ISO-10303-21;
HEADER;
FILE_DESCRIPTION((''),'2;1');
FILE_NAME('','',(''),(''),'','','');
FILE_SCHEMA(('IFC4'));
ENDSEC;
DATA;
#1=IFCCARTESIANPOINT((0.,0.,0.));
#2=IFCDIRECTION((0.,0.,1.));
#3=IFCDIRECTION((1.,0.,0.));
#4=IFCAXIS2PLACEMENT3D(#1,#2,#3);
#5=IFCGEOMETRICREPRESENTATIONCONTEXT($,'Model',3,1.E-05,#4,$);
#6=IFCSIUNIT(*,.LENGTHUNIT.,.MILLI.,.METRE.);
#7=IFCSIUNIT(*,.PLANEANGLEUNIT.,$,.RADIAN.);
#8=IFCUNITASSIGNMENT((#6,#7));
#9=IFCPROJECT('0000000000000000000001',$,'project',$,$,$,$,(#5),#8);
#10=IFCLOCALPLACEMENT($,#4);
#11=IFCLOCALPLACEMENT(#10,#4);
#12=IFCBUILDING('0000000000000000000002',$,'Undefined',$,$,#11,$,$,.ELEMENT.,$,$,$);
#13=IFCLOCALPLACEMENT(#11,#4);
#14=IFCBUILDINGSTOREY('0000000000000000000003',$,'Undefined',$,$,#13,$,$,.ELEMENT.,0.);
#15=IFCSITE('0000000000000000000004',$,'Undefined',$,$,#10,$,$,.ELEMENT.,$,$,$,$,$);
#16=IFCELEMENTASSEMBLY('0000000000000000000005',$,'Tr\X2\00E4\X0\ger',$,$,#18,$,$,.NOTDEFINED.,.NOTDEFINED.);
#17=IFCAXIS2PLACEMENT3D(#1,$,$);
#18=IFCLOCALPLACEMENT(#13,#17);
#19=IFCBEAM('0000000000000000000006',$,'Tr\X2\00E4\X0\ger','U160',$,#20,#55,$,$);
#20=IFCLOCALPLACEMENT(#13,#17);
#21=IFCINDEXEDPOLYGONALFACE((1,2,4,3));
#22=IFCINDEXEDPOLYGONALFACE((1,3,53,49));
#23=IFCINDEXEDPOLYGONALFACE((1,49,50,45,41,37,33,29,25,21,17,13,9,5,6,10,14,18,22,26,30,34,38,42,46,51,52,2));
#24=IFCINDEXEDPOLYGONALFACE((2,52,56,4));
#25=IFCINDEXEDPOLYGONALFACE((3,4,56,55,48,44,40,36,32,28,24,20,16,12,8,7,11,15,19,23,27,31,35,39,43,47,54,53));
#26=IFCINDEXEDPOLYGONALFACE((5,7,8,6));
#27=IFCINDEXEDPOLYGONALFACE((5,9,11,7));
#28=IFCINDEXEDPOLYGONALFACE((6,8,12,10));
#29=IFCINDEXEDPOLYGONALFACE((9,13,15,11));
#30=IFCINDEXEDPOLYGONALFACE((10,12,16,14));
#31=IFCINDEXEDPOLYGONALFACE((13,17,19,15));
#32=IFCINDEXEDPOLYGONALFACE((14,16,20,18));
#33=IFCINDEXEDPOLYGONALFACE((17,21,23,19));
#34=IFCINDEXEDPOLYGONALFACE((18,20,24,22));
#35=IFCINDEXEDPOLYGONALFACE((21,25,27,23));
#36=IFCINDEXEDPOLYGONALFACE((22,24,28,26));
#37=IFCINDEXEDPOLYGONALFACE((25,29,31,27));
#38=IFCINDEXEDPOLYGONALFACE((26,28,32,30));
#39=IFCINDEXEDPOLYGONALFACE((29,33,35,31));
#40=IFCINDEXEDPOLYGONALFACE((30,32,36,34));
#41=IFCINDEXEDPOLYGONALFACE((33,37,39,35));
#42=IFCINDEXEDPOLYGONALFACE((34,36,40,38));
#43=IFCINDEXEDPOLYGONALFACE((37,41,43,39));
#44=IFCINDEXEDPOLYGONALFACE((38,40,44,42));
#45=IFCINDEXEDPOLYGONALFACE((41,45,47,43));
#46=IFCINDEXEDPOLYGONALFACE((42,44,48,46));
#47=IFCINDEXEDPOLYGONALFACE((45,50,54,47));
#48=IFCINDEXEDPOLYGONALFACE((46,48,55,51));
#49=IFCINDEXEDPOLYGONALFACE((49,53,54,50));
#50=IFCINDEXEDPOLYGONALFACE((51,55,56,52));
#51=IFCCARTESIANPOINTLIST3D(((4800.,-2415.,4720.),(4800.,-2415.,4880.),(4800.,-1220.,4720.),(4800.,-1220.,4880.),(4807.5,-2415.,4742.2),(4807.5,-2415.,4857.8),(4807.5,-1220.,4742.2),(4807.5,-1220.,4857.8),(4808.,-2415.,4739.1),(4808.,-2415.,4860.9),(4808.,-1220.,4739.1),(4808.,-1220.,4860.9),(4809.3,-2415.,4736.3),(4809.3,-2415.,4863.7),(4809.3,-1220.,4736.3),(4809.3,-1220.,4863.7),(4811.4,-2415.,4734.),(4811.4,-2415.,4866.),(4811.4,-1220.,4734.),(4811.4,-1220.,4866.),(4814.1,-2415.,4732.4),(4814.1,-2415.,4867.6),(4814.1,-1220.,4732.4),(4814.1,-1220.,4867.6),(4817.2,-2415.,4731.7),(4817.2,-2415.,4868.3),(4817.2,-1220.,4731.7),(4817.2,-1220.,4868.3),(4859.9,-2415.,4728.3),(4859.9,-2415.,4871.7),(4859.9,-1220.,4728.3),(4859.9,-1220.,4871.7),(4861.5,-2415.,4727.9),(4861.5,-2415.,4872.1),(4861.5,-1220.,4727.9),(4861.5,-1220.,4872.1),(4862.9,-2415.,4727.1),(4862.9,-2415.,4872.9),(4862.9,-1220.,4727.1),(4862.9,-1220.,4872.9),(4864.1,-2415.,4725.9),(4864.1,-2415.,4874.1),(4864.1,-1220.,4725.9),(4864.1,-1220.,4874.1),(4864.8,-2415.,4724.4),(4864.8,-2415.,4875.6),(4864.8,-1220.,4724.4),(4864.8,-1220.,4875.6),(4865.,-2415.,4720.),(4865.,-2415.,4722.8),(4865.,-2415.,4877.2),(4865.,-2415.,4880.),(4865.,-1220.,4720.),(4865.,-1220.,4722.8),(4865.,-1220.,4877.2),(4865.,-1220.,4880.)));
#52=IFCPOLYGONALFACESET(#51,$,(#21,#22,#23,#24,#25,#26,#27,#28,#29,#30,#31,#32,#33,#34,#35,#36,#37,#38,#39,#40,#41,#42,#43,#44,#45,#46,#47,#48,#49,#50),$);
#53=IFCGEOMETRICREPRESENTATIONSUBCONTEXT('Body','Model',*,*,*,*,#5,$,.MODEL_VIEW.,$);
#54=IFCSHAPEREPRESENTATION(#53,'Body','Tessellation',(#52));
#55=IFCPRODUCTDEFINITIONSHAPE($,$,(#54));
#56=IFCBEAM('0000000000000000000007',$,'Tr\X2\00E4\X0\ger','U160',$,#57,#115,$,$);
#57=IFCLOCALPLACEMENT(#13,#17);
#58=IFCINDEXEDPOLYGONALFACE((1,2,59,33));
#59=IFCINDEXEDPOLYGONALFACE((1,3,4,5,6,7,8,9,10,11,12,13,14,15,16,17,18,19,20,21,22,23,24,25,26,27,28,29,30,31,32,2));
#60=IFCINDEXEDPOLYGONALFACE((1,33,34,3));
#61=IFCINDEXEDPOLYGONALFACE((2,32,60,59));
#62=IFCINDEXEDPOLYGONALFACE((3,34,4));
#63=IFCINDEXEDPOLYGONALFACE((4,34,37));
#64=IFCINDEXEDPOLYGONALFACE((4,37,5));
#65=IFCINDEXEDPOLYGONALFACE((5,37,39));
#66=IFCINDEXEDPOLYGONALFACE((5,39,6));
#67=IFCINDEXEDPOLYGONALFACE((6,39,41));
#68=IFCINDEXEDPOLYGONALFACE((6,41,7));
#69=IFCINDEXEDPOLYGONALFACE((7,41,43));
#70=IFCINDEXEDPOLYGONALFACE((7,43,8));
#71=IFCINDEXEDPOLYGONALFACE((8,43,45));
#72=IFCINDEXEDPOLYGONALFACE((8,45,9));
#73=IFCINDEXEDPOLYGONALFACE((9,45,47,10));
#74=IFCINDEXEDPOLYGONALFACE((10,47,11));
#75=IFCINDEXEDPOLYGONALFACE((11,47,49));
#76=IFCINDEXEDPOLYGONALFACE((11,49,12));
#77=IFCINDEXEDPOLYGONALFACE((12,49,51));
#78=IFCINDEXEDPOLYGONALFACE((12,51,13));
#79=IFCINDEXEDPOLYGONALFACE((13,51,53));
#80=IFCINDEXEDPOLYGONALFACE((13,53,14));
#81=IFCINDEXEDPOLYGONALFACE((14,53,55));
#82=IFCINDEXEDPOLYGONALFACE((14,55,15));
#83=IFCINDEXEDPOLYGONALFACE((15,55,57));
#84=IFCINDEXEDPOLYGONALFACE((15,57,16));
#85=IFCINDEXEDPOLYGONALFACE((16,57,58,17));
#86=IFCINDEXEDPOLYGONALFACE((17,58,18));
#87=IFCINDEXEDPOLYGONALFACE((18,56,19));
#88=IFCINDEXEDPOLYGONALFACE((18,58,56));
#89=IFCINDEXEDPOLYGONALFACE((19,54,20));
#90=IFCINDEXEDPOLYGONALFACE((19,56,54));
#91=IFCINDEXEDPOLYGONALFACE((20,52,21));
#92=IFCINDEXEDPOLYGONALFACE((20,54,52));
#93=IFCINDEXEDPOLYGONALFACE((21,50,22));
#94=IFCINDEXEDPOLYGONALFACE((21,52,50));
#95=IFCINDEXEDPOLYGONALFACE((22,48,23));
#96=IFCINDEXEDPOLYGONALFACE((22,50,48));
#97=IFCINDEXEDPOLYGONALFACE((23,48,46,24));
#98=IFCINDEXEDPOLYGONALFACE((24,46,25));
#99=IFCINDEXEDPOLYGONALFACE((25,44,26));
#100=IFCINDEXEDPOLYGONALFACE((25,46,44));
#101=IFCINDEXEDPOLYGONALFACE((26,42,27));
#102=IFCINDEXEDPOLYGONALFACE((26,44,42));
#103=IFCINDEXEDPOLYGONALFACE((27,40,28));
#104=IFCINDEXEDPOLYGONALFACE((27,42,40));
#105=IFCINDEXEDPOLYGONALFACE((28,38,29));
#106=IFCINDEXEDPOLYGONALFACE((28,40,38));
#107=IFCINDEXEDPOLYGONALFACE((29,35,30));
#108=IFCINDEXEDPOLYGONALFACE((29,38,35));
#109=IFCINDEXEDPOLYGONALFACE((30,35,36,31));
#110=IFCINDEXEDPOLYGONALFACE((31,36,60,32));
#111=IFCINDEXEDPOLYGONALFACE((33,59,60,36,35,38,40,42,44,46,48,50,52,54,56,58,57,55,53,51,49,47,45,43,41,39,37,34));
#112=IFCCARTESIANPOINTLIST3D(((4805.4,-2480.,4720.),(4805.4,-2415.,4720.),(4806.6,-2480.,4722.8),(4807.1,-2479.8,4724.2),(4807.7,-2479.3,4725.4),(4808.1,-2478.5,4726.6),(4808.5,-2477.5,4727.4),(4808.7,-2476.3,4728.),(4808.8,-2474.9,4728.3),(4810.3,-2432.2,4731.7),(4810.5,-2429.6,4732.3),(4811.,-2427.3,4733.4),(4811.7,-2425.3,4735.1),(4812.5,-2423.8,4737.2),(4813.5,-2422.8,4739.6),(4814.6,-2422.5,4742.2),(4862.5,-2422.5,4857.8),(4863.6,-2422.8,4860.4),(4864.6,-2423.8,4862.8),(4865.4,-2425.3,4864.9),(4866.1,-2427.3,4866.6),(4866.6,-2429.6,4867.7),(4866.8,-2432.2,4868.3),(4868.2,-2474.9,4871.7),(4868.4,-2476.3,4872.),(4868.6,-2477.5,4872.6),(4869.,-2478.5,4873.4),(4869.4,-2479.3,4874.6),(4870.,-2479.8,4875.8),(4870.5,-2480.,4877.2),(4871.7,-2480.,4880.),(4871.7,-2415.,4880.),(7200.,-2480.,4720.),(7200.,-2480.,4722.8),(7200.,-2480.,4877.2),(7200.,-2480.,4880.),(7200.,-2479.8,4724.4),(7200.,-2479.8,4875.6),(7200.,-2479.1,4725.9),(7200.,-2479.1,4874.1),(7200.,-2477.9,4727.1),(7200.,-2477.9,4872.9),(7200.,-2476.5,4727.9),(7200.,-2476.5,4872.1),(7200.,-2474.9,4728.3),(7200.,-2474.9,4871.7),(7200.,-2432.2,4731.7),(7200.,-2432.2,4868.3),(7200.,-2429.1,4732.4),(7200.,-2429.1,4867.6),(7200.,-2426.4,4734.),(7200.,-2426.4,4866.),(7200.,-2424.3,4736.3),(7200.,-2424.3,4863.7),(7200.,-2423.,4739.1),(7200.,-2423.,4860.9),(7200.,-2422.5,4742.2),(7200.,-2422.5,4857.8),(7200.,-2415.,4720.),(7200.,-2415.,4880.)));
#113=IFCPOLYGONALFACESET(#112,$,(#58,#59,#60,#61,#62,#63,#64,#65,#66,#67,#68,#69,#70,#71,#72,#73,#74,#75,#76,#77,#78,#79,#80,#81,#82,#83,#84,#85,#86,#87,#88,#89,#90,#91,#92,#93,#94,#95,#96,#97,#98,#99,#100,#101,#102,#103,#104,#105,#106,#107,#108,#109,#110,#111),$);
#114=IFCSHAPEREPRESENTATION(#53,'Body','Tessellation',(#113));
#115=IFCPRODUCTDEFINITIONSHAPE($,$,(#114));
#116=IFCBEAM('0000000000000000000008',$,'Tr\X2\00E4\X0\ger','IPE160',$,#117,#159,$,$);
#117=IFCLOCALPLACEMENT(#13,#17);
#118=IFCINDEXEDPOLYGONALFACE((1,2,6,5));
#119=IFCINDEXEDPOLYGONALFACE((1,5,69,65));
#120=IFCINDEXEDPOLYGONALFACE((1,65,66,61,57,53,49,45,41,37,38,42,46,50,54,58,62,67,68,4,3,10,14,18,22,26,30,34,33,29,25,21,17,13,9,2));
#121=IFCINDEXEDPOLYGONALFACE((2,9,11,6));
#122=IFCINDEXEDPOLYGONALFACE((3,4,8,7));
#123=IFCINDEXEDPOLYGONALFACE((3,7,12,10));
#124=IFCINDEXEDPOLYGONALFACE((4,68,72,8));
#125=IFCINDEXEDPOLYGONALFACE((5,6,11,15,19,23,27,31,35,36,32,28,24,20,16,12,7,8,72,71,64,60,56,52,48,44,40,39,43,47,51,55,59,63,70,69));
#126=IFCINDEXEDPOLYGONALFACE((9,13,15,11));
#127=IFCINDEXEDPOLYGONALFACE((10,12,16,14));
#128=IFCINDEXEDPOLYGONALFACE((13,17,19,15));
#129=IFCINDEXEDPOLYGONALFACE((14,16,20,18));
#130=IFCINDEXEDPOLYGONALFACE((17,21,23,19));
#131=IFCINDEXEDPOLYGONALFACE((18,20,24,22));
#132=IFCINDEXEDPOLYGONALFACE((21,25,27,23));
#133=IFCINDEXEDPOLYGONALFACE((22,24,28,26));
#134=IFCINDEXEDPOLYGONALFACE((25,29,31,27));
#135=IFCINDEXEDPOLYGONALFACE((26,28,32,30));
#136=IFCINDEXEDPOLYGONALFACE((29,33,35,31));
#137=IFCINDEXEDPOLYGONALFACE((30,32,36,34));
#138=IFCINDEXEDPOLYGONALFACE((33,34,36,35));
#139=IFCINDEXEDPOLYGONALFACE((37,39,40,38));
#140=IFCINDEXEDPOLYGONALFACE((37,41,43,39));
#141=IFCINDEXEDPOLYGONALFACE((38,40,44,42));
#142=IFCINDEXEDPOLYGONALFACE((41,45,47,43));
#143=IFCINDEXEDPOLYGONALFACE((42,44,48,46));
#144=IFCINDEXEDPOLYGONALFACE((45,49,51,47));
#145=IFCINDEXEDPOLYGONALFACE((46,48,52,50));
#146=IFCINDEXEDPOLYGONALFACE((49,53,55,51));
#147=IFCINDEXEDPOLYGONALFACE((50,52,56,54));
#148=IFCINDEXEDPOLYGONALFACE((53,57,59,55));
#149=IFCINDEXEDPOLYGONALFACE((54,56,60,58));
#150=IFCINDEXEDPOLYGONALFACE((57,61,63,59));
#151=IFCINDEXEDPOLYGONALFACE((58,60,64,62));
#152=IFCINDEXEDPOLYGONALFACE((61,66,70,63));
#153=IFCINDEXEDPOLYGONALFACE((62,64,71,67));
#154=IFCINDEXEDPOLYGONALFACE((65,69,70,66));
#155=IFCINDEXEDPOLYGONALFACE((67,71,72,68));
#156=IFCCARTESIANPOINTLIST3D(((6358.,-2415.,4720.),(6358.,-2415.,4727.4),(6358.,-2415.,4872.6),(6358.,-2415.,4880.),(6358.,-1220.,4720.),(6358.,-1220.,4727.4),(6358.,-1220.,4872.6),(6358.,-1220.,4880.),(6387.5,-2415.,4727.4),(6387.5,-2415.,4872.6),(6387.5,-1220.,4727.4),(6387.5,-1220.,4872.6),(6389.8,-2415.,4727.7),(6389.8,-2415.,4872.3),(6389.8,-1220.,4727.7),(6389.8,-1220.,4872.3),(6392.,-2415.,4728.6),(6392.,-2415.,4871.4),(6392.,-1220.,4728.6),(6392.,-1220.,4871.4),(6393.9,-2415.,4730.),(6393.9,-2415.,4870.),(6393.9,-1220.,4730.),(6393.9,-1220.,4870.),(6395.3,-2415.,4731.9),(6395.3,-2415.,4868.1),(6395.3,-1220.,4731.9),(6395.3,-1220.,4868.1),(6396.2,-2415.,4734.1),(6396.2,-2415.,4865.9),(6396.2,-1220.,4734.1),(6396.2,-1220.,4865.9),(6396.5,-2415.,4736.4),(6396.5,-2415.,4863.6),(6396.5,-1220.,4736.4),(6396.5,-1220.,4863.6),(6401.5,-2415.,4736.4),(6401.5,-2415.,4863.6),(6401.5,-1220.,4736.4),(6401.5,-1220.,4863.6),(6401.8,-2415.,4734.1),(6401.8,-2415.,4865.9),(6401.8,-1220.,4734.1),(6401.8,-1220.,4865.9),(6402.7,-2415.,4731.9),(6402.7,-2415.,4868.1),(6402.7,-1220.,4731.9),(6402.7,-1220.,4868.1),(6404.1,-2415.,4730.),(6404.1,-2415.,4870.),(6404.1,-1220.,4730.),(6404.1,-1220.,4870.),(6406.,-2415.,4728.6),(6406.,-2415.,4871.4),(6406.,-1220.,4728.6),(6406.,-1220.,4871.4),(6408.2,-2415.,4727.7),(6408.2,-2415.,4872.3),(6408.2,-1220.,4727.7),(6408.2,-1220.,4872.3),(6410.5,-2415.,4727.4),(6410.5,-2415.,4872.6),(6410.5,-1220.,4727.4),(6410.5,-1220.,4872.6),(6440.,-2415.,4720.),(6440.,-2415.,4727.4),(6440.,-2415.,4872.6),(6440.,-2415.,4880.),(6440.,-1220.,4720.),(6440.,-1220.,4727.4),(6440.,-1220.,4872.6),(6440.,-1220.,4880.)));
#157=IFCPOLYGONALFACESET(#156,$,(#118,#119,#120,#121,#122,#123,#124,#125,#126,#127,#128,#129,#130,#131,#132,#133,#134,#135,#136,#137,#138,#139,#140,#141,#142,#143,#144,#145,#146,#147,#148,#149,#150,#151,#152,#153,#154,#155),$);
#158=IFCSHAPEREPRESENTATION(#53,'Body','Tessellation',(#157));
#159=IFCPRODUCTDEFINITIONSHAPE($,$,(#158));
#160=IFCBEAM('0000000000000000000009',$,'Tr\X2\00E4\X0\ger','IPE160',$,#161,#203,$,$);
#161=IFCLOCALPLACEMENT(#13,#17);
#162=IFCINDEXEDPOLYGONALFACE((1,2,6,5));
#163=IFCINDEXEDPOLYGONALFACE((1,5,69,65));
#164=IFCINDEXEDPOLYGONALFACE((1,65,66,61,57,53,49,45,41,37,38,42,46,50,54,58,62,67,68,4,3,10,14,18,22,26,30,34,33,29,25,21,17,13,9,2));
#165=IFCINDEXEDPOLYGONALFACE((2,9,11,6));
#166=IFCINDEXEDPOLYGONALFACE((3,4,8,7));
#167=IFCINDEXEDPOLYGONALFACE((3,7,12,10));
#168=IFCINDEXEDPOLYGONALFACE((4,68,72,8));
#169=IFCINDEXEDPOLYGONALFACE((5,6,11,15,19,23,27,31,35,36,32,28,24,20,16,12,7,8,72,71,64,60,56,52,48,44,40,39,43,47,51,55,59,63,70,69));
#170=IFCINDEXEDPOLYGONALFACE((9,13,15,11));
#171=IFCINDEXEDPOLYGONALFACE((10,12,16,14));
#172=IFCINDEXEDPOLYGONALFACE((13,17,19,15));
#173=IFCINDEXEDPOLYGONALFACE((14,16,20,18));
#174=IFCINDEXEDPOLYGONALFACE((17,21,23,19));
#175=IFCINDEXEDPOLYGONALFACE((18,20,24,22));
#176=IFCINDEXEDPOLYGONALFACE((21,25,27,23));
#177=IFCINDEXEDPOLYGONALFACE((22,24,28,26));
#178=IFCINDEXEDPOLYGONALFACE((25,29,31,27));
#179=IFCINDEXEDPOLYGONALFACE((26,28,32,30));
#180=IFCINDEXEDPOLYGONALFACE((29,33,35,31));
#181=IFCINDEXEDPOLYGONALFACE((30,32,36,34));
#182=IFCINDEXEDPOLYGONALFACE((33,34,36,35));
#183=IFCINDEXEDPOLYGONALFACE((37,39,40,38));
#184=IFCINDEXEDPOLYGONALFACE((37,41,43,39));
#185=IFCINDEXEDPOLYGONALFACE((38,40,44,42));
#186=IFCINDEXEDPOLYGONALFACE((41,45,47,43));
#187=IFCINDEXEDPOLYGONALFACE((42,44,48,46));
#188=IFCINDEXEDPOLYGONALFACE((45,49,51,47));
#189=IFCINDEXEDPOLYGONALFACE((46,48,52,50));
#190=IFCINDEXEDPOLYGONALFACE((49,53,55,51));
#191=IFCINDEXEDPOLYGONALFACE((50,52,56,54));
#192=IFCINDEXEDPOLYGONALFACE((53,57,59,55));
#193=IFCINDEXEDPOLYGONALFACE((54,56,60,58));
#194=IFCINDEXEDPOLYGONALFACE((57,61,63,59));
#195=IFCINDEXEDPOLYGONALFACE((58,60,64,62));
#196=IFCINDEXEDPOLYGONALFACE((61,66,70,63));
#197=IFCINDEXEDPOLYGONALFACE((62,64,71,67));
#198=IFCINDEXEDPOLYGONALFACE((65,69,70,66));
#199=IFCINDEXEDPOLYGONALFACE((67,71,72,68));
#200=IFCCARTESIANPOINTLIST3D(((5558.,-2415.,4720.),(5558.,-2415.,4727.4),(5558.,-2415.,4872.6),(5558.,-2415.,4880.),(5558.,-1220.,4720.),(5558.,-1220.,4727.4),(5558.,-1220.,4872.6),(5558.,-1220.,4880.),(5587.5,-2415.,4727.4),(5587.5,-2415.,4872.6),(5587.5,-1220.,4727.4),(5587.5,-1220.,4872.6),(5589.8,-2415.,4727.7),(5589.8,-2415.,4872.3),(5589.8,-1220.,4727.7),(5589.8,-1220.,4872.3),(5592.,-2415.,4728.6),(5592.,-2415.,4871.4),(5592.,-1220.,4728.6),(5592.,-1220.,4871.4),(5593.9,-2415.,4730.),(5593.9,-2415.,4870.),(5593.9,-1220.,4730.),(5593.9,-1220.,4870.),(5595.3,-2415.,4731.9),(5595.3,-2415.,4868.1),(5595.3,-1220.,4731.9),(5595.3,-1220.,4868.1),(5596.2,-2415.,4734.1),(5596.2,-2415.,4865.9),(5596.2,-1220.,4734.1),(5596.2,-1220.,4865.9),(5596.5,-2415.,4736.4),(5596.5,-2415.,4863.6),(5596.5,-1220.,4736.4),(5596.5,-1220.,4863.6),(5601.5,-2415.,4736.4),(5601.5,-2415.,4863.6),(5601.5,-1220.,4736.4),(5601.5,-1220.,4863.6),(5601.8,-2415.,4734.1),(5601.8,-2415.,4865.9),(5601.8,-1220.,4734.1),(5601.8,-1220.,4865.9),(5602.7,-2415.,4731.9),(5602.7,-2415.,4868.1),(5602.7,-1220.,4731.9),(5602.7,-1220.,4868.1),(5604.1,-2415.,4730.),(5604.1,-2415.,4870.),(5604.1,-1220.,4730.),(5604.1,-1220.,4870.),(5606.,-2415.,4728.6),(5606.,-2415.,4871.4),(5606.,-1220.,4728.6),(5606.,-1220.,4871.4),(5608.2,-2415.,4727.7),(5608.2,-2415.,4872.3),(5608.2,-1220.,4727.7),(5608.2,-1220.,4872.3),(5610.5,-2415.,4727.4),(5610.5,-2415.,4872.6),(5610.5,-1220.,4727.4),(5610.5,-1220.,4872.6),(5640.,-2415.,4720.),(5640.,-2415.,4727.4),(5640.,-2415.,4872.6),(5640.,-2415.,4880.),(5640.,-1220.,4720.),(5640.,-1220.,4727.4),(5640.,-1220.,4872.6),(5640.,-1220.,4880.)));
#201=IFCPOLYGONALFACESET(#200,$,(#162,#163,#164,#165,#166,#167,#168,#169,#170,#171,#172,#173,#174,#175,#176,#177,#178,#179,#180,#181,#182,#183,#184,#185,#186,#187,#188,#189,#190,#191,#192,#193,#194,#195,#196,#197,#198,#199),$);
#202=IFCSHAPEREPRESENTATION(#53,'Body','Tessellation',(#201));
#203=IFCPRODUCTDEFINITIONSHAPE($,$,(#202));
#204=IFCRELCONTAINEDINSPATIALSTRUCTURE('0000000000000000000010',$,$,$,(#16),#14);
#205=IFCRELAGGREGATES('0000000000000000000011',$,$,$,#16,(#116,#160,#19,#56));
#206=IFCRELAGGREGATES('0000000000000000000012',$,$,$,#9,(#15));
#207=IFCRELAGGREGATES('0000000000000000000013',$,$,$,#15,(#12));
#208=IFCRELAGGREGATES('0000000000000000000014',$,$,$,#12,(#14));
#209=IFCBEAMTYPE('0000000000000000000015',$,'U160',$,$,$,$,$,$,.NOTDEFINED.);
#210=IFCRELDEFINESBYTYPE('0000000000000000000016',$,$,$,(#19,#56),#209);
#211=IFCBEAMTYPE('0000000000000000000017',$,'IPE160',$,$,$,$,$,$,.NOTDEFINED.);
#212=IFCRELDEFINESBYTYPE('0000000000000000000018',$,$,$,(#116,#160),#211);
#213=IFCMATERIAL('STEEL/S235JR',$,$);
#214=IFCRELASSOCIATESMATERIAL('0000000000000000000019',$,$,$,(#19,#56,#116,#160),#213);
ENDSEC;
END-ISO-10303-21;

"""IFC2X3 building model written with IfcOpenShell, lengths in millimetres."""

from ifc_helpers import new_model, si_unit, frame, origin_with_axes, origin_2d_with_axis, place, context, subcontext, project, spatial, i_section, u_section, extrude, clip, halfspace, material, type_object, element, aggregate, save


model = new_model("IFC2X3")

# Units and contexts
model_context = context("Model", 3, precision=1e-05, world=origin_with_axes())
body_context = subcontext(model_context, "Body", "Model", "MODEL_VIEW")
ifc_project = project(units=[si_unit("LENGTHUNIT", "METRE", prefix="MILLI"), si_unit("PLANEANGLEUNIT", "RADIAN")], contexts=[model_context])

# Site, building, storey
site_placement = place(None, origin_with_axes())
site = spatial("IfcSite", under=ifc_project, at=site_placement, Name="Undefined", CompositionType="ELEMENT")
building_placement = place(site_placement, origin_with_axes())
building = spatial("IfcBuilding", under=site, at=building_placement, Name="Undefined", CompositionType="ELEMENT")
storey_placement = place(building_placement, origin_with_axes())
storey = spatial("IfcBuildingStorey", under=building, at=storey_placement, Name="Undefined", CompositionType="ELEMENT", Elevation=0.0)

# Shared definitions
ifc_material_1 = material(Name="STEEL/S235JR")

# Element assembly
assembly_1_placement = place(storey_placement, origin_with_axes())
assembly_1 = element("IfcElementAssembly", 1, at=assembly_1_placement, inside=storey, Name="Träger", AssemblyPlace="NOTDEFINED", PredefinedType="NOTDEFINED")

# Beams
beam_type_1 = type_object("IfcBeamType", Name="U160", PredefinedType="NOTDEFINED")
beam_1_placement = place(assembly_1_placement, frame((4832.5, -1220.0, 4800.0), z_axis=(0.0, 0.0, -1.0), x_axis=(0.0, -1.0, 0.0)))
beam_1 = element("IfcBeam", 2, at=beam_1_placement, type_object=beam_type_1, material=ifc_material_1, Name="Träger", Description="U160", context=body_context, shape_type="SweptSolid", body=[
    extrude(u_section(Depth=160.0, FlangeWidth=65.0, WebThickness=7.5, FlangeThickness=10.5, FilletRadius=10.5, EdgeRadius=5.5, FlangeSlope=0.07983, at=origin_2d_with_axis()), frame((1195.0, 0.0, 0.0), z_axis=(-1.0, 0.0, 0.0), x_axis=(0.0, -1.0, 0.0)), (0.0, 0.0, 1.0), 1195.0),
])
beam_2_placement = place(assembly_1_placement, frame((4866.3, -2447.5, 4800.0), z_axis=(0.0, 0.0, 1.0), x_axis=(1.0, 0.0, 0.0)))
beam_2 = element("IfcBeam", 3, at=beam_2_placement, type_object=beam_type_1, material=ifc_material_1, Name="Träger", Description="U160", context=body_context, shape_type="Clipping", body=[
    clip(extrude(u_section(Depth=160.0, FlangeWidth=65.0, WebThickness=7.5, FlangeThickness=10.5, FilletRadius=10.5, EdgeRadius=5.5, FlangeSlope=0.07983, at=origin_2d_with_axis()), frame((2333.7, 0.0, 0.0), z_axis=(-1.0, 0.0, 0.0), x_axis=(0.0, -1.0, 0.0)), (0.0, 0.0, 1.0), 2394.9), halfspace(frame((4.6, 0.0, 78.1), z_axis=(0.92388, 0.0, -0.382683), x_axis=(0.0, 1.0, 0.0)), True)),
])

# Beams
beam_type_2 = type_object("IfcBeamType", Name="IPE160", PredefinedType="NOTDEFINED")
beam_3_placement = place(assembly_1_placement, frame((6399.0, -1220.0, 4800.0), z_axis=(0.0, 0.0, -1.0), x_axis=(0.0, -1.0, 0.0)))
beam_3 = element("IfcBeam", 4, at=beam_3_placement, type_object=beam_type_2, material=ifc_material_1, Name="Träger", Description="IPE160", context=body_context, shape_type="SweptSolid", body=[
    extrude(i_section(OverallWidth=82.0, OverallDepth=160.0, WebThickness=5.0, FlangeThickness=7.4, FilletRadius=9.0, at=origin_2d_with_axis()), frame((1195.0, 0.0, 0.0), z_axis=(-1.0, 0.0, 0.0), x_axis=(0.0, -1.0, 0.0)), (0.0, 0.0, 1.0), 1195.0),
])
beam_4_placement = place(assembly_1_placement, frame((5599.0, -1220.0, 4800.0), z_axis=(0.0, 0.0, -1.0), x_axis=(0.0, -1.0, 0.0)))
beam_4 = element("IfcBeam", 5, at=beam_4_placement, type_object=beam_type_2, material=ifc_material_1, Name="Träger", Description="IPE160", context=body_context, shape_type="SweptSolid", body=[
    extrude(i_section(OverallWidth=82.0, OverallDepth=160.0, WebThickness=5.0, FlangeThickness=7.4, FilletRadius=9.0, at=origin_2d_with_axis()), frame((1195.0, 0.0, 0.0), z_axis=(-1.0, 0.0, 0.0), x_axis=(0.0, -1.0, 0.0)), (0.0, 0.0, 1.0), 1195.0),
])
aggregate(assembly_1, [beam_3, beam_4, beam_1, beam_2])

save(model, "model.ifc")
